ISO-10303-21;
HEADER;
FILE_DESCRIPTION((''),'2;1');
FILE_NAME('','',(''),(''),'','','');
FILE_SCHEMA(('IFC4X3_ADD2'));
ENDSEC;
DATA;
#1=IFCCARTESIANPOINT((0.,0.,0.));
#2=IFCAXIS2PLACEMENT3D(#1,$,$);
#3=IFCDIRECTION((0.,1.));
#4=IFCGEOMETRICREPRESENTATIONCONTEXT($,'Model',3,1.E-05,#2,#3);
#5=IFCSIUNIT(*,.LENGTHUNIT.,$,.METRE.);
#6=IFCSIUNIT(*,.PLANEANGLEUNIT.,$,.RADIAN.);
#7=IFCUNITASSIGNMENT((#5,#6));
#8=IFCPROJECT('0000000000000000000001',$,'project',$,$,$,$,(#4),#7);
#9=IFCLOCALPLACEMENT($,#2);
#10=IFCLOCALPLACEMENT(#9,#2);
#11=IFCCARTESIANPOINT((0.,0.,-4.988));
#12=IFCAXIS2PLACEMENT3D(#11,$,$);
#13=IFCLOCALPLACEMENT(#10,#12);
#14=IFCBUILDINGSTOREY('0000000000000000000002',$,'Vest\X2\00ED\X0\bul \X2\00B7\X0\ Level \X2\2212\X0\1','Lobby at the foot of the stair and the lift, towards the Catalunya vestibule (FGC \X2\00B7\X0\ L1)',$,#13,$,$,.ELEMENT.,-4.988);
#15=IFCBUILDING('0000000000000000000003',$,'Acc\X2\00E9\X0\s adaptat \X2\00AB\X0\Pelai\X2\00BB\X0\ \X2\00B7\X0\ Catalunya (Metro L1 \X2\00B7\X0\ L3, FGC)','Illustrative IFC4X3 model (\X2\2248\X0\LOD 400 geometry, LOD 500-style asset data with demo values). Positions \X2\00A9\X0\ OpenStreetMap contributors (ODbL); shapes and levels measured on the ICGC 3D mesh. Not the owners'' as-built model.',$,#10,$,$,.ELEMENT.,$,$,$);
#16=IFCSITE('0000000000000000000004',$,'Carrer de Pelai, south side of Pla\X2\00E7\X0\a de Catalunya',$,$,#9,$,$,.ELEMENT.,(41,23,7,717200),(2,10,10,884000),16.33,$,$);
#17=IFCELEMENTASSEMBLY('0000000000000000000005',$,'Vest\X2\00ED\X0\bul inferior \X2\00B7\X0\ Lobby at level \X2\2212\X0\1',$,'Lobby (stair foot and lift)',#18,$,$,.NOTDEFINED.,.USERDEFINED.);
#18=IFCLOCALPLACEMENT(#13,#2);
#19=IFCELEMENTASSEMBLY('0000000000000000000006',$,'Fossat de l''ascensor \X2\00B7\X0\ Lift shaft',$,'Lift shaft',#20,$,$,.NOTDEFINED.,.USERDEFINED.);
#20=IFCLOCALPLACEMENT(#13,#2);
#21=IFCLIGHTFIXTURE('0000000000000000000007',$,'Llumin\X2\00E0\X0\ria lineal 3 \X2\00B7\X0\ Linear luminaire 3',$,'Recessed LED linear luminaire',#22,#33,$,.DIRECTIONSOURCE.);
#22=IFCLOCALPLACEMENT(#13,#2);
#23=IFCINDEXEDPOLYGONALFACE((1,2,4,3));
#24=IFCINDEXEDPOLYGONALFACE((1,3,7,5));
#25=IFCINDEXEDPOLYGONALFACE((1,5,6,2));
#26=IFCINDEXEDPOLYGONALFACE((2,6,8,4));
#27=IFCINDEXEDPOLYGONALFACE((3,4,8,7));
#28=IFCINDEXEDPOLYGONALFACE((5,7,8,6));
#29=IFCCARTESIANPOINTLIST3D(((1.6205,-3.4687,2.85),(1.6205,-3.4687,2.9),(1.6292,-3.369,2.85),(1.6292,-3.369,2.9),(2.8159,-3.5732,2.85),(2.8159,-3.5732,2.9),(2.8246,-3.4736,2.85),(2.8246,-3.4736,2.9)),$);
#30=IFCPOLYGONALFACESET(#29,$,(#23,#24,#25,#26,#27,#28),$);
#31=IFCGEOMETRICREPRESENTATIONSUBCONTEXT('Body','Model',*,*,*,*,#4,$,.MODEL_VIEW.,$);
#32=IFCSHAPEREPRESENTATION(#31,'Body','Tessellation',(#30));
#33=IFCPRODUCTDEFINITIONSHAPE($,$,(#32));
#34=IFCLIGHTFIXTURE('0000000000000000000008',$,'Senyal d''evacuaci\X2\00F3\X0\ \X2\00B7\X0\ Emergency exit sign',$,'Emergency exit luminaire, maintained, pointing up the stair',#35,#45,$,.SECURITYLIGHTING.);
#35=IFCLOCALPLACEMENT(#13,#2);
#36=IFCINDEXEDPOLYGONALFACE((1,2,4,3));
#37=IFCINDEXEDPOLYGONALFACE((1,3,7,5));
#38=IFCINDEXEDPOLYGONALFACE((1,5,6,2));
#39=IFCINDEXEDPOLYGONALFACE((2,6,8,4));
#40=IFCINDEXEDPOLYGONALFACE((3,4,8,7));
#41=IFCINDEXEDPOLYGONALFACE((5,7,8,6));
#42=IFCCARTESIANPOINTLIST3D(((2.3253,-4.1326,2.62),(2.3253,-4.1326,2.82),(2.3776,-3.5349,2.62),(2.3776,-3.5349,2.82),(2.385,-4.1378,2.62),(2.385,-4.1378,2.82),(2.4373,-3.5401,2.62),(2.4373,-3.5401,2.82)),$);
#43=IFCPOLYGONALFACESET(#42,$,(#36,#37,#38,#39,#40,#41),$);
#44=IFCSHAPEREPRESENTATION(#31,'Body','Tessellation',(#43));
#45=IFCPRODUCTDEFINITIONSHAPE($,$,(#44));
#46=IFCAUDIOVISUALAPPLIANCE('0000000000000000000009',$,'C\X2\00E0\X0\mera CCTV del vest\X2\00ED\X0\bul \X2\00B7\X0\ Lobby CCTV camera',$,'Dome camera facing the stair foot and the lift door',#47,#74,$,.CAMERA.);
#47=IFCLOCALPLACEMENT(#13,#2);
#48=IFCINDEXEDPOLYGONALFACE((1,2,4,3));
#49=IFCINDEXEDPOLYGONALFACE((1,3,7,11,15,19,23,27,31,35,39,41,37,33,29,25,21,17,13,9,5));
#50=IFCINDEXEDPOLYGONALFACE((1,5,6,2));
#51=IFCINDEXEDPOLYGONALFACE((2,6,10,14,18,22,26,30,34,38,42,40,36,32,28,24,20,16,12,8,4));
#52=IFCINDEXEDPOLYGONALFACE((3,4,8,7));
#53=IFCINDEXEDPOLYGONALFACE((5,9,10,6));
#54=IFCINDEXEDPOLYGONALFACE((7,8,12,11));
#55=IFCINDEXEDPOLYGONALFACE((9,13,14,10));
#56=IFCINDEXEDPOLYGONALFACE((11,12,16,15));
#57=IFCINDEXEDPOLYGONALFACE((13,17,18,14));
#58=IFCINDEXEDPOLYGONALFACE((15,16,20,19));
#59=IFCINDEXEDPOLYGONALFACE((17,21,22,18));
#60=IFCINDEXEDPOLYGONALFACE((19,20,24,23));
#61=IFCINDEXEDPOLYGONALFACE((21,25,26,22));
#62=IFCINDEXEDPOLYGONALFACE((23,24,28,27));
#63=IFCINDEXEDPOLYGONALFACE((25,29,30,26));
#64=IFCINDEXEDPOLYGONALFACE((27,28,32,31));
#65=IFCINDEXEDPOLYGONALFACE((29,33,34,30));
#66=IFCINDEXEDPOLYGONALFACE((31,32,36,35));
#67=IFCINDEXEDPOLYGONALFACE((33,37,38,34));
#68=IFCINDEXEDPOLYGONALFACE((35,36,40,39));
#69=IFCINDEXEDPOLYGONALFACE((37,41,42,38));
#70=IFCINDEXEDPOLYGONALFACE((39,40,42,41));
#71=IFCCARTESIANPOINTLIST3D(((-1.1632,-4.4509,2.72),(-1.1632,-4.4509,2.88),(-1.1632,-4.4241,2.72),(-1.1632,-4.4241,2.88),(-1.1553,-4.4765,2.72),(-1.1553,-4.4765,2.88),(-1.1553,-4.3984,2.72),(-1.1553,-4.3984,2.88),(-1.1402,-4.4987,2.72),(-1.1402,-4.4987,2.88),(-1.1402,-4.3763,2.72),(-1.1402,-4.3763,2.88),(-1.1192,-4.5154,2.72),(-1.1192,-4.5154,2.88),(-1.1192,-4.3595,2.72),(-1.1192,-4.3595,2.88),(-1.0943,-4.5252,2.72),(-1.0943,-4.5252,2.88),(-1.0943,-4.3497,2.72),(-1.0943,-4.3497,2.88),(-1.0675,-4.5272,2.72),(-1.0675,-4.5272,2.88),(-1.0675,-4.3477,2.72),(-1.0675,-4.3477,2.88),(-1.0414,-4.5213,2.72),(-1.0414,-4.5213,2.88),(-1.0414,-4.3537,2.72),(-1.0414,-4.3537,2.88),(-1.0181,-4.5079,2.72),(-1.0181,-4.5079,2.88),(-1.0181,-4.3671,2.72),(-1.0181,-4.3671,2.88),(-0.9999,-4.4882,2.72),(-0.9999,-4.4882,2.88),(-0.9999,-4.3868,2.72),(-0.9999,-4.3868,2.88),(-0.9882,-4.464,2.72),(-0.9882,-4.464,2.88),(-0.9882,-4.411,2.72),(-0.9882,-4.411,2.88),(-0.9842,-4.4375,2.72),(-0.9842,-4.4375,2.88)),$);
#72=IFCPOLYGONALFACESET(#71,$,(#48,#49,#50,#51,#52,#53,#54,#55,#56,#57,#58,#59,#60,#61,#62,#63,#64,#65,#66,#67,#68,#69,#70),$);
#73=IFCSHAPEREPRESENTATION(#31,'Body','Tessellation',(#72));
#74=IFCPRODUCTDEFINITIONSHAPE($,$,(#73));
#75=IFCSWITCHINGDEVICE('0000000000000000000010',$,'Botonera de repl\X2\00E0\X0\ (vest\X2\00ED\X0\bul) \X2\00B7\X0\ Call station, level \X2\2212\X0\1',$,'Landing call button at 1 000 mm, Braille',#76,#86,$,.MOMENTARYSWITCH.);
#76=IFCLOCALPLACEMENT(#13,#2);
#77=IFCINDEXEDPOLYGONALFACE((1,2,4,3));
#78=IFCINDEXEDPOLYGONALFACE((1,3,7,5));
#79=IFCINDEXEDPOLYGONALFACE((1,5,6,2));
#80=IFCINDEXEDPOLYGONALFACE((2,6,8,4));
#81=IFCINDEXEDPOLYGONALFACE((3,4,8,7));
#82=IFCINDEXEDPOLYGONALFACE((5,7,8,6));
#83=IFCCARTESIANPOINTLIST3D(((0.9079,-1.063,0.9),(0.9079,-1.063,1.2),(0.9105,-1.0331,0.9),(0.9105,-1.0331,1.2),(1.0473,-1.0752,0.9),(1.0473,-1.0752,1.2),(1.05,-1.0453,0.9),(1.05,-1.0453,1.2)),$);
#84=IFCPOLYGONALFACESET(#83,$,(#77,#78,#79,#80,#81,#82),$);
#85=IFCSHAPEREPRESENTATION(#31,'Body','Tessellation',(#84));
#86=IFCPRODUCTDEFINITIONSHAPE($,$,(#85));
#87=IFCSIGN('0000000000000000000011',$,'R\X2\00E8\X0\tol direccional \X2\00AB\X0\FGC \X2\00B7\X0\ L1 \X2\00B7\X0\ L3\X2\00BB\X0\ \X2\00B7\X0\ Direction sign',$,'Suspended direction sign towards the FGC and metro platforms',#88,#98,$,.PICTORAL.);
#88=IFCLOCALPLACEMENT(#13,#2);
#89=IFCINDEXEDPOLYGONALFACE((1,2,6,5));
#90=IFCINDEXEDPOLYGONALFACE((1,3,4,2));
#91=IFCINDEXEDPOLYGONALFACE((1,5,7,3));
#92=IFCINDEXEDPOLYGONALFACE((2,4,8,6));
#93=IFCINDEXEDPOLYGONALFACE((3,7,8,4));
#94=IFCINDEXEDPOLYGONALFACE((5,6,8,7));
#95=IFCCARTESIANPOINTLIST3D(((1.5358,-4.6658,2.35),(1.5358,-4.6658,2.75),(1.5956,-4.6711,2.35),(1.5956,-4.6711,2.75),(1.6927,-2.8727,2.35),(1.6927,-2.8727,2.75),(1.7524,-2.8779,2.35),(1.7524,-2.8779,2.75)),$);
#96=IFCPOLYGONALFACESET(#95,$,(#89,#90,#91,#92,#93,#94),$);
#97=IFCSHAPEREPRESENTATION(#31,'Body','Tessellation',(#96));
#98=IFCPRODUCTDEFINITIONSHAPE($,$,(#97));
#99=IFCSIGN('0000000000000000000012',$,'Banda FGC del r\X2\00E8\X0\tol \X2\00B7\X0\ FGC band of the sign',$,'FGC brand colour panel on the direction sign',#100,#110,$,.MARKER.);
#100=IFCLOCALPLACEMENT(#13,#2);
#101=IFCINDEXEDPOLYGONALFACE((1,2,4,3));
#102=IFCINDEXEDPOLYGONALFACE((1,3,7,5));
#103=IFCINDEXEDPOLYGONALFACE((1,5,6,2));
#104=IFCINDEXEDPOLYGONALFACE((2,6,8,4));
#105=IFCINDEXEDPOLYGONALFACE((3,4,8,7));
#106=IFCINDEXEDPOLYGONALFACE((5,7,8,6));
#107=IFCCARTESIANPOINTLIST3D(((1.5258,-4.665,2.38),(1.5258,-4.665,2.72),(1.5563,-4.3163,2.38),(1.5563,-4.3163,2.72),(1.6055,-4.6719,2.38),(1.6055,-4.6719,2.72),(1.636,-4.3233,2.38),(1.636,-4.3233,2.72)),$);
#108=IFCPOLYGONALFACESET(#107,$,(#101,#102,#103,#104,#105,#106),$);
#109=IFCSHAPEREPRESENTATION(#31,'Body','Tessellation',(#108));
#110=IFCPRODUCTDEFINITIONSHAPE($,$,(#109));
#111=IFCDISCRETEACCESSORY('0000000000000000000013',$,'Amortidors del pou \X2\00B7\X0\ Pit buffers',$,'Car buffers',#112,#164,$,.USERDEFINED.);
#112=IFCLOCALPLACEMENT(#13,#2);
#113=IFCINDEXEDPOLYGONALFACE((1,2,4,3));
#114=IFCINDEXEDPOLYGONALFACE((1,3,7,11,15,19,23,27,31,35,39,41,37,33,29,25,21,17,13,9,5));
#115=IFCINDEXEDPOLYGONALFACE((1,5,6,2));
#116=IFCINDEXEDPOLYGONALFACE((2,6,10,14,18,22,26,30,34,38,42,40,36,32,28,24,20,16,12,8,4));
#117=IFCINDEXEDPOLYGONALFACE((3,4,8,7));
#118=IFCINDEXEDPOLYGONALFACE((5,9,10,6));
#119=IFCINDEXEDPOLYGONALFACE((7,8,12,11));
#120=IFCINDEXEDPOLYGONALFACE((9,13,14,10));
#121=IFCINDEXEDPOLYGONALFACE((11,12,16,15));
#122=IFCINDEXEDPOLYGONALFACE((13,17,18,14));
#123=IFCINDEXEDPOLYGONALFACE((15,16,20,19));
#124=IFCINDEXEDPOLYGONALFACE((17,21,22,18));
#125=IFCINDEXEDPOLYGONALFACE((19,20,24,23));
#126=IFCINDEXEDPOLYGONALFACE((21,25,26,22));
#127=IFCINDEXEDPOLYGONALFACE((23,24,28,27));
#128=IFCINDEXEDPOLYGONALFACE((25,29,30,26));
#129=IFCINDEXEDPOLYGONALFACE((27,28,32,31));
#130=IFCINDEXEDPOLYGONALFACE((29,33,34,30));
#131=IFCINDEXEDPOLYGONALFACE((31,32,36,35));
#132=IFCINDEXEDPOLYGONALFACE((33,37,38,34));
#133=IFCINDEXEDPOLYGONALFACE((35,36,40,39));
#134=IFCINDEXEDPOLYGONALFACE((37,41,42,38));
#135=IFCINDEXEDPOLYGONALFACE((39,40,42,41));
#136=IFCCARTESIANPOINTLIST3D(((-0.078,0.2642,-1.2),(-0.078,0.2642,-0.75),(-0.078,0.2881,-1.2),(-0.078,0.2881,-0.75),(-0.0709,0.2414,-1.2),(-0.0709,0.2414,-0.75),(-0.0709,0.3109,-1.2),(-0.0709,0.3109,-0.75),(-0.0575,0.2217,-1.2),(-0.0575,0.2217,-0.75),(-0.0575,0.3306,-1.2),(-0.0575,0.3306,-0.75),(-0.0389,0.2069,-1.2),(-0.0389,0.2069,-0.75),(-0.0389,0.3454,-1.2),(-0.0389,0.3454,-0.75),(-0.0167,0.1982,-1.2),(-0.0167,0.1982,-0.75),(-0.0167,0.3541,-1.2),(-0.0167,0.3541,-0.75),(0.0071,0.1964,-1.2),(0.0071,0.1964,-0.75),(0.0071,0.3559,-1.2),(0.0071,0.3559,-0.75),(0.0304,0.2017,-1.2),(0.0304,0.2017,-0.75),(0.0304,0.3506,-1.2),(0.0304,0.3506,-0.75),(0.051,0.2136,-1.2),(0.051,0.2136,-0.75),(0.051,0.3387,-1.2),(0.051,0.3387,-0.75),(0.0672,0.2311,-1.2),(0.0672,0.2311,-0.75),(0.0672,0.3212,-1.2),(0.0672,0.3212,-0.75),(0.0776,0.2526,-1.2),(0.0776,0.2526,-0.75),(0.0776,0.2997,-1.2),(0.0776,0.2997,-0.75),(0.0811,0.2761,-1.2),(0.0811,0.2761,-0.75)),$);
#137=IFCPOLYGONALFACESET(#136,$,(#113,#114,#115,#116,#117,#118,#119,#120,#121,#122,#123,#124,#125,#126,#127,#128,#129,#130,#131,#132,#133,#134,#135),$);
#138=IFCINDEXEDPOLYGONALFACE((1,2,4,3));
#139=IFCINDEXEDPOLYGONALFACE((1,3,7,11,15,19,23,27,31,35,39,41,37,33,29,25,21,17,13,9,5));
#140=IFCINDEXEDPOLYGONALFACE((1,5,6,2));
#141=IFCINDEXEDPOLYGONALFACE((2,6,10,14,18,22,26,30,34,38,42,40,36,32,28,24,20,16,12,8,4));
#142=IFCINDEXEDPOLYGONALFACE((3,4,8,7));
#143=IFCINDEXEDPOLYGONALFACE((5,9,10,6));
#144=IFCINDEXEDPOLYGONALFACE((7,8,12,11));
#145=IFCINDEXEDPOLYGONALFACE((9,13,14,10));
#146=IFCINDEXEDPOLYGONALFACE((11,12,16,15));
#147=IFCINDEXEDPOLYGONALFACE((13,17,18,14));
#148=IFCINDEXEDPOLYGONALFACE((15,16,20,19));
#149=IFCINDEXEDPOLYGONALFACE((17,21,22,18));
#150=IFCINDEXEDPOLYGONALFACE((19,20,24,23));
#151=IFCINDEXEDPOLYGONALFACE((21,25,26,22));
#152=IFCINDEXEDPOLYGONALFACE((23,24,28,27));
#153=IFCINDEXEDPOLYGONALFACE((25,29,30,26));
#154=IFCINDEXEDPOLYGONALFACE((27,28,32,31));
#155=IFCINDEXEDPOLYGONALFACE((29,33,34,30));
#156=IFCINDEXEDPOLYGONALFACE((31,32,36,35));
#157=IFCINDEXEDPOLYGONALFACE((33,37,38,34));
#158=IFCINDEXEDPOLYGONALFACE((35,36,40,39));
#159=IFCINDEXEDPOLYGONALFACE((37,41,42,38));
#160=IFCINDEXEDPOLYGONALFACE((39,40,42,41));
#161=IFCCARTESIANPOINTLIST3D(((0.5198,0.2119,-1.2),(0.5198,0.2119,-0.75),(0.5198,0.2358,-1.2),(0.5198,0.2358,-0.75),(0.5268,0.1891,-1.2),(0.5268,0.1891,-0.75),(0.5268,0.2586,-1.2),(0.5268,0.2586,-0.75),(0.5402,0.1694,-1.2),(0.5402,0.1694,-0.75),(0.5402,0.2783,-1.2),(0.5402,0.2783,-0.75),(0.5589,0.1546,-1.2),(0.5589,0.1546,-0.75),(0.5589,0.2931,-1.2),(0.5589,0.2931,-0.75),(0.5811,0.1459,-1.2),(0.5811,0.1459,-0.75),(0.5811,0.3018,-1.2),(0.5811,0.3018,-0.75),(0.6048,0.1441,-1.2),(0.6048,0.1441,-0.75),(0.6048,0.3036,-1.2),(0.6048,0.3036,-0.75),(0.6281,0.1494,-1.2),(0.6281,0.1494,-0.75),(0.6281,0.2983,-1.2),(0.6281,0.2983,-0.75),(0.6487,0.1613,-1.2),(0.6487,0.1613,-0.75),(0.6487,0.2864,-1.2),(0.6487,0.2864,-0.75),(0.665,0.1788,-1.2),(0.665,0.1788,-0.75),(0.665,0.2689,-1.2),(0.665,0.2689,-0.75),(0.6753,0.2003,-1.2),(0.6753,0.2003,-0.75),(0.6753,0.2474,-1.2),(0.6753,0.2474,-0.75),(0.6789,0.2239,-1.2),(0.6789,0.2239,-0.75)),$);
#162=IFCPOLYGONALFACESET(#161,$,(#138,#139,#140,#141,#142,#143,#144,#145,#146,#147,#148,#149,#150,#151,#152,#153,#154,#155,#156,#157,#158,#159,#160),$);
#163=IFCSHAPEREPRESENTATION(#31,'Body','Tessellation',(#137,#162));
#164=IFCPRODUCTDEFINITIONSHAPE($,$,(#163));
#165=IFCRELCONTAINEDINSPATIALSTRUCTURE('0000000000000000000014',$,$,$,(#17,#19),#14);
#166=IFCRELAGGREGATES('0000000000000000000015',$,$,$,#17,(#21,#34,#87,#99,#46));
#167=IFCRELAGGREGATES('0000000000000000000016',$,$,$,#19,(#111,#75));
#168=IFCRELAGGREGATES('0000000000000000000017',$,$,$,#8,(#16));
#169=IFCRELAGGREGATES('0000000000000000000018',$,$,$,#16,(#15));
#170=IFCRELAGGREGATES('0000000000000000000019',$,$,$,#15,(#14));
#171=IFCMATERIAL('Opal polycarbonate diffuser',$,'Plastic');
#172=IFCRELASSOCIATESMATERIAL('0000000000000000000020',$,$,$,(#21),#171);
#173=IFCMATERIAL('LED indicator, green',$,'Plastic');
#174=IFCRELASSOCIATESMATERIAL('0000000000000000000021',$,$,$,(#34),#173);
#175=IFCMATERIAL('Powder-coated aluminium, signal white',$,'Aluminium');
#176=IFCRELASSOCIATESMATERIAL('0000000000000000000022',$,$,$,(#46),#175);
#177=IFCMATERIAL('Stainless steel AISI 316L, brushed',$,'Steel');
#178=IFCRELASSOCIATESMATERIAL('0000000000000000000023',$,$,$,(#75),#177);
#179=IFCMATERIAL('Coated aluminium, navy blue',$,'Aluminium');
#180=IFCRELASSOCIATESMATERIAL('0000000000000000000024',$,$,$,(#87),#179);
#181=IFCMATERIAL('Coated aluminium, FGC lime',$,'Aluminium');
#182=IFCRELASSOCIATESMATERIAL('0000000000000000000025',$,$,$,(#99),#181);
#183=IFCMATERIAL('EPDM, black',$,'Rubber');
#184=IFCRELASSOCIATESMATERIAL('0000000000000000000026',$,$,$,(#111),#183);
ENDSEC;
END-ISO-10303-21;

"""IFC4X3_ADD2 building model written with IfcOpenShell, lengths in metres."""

from ifc_helpers import new_model, si_unit, direction, frame, frame_2d, origin, origin_2d_with_axis, place, context, subcontext, project, spatial, rectangle, circle, extrude, material, element, aggregate, save


model = new_model("IFC4X3_ADD2")

# Units and contexts
model_context = context("Model", 3, precision=1e-05, world=origin(), true_north=direction((0.0, 1.0)))
body_context = subcontext(model_context, "Body", "Model", "MODEL_VIEW")
ifc_project = project(units=[si_unit("LENGTHUNIT", "METRE"), si_unit("PLANEANGLEUNIT", "RADIAN")], contexts=[model_context])

# Site, building, storey
site_placement = place(None, origin())
site = spatial("IfcSite", under=ifc_project, at=site_placement, Name="Carrer de Pelai, south side of Plaça de Catalunya", CompositionType="ELEMENT", RefLatitude=(41, 23, 7, 717200), RefLongitude=(2, 10, 10, 884000), RefElevation=16.33)
building_placement = place(site_placement, origin())
building = spatial("IfcBuilding", under=site, at=building_placement, Name="Accés adaptat «Pelai» · Catalunya (Metro L1 · L3, FGC)", Description="Illustrative IFC4X3 model (≈LOD 400 geometry, LOD 500-style asset data with demo values). Positions © OpenStreetMap contributors (ODbL); shapes and levels measured on the ICGC 3D mesh. Not the owners' as-built model.", CompositionType="ELEMENT")
storey_placement = place(building_placement, frame((0.0, 0.0, -4.988)))
storey = spatial("IfcBuildingStorey", under=building, at=storey_placement, Name="Vestíbul · Level −1", Description="Lobby at the foot of the stair and the lift, towards the Catalunya vestibule (FGC · L1)", CompositionType="ELEMENT", Elevation=-4.988)

# Element assembly
assembly_1_placement = place(building_placement, origin())
assembly_1 = element("IfcElementAssembly", 1, at=assembly_1_placement, inside=storey, Name="Vestíbul inferior · Lobby at level −1", ObjectType="Lobby (stair foot and lift)", AssemblyPlace="NOTDEFINED", PredefinedType="USERDEFINED")

# Element assembly
assembly_2_placement = place(building_placement, origin())
assembly_2 = element("IfcElementAssembly", 2, at=assembly_2_placement, inside=storey, Name="Fossat de l'ascensor · Lift shaft", ObjectType="Lift shaft", AssemblyPlace="NOTDEFINED", PredefinedType="USERDEFINED")

# Shared definitions
ifc_material_1 = material(Name="Stainless steel AISI 316L, brushed", Category="Steel")

# Light fixtures
ifc_material_2 = material(Name="Opal polycarbonate diffuser", Category="Plastic")
light_fixture_1_placement = place(building_placement, origin())
light_fixture_1 = element("IfcLightFixture", 3, at=light_fixture_1_placement, material=ifc_material_2, Name="Lluminària lineal 3 · Linear luminaire 3", ObjectType="Recessed LED linear luminaire", PredefinedType="DIRECTIONSOURCE", context=body_context, shape_type="SweptSolid", body=[
    extrude(rectangle(XDim=1.2, YDim=0.1, at=frame_2d((0.0, 0.0), x_axis=(0.996195, -0.087156))), frame((2.2225, -3.4711, -2.138)), (0.0, 0.0, 1.0), 0.05),
])
ifc_material_3 = material(Name="LED indicator, green", Category="Plastic")
light_fixture_2_placement = place(building_placement, origin())
light_fixture_2 = element("IfcLightFixture", 4, at=light_fixture_2_placement, material=ifc_material_3, Name="Senyal d'evacuació · Emergency exit sign", ObjectType="Emergency exit luminaire, maintained, pointing up the stair", PredefinedType="SECURITYLIGHTING", context=body_context, shape_type="SweptSolid", body=[
    extrude(rectangle(XDim=0.06, YDim=0.6, at=frame_2d((0.0, 0.0), x_axis=(0.996195, -0.087156))), frame((2.3813, -3.8364, -2.368)), (0.0, 0.0, 1.0), 0.2),
])

# Audio visual appliance
ifc_material_4 = material(Name="Powder-coated aluminium, signal white", Category="Aluminium")
audio_visual_appliance_placement = place(building_placement, origin())
audio_visual_appliance = element("IfcAudioVisualAppliance", 5, at=audio_visual_appliance_placement, material=ifc_material_4, Name="Càmera CCTV del vestíbul · Lobby CCTV camera", ObjectType="Dome camera facing the stair foot and the lift door", PredefinedType="CAMERA", context=body_context, shape_type="SweptSolid", body=[
    extrude(circle(Radius=0.09, at=origin_2d_with_axis()), frame((-1.0742, -4.4375, -2.268)), (0.0, 0.0, 1.0), 0.16),
])

# Switching device
switching_device_placement = place(building_placement, origin())
switching_device = element("IfcSwitchingDevice", 6, at=switching_device_placement, material=ifc_material_1, Name="Botonera de replà (vestíbul) · Call station, level −1", ObjectType="Landing call button at 1 000 mm, Braille", PredefinedType="MOMENTARYSWITCH", context=body_context, shape_type="SweptSolid", body=[
    extrude(rectangle(XDim=0.14, YDim=0.03, at=frame_2d((0.0, 0.0), x_axis=(0.996195, -0.087156))), frame((0.9789, -1.0541, -4.088)), (0.0, 0.0, 1.0), 0.3),
])

# Signs
ifc_material_5 = material(Name="Coated aluminium, navy blue", Category="Aluminium")
sign_1_placement = place(building_placement, origin())
sign_1 = element("IfcSign", 7, at=sign_1_placement, material=ifc_material_5, Name="Rètol direccional «FGC · L1 · L3» · Direction sign", ObjectType="Suspended direction sign towards the FGC and metro platforms", PredefinedType="PICTORAL", context=body_context, shape_type="SweptSolid", body=[
    extrude(rectangle(XDim=0.06, YDim=1.8, at=frame_2d((0.0, 0.0), x_axis=(0.996195, -0.087156))), frame((1.6441, -3.7719, -2.638)), (0.0, 0.0, 1.0), 0.4),
])
ifc_material_6 = material(Name="Coated aluminium, FGC lime", Category="Aluminium")
sign_2_placement = place(building_placement, origin())
sign_2 = element("IfcSign", 8, at=sign_2_placement, material=ifc_material_6, Name="Banda FGC del rètol · FGC band of the sign", ObjectType="FGC brand colour panel on the direction sign", PredefinedType="MARKER", context=body_context, shape_type="SweptSolid", body=[
    extrude(rectangle(XDim=0.08, YDim=0.35, at=frame_2d((0.0, 0.0), x_axis=(0.996195, -0.087156))), frame((1.5809, -4.4941, -2.608)), (0.0, 0.0, 1.0), 0.34),
])
aggregate(assembly_1, [light_fixture_1, light_fixture_2, sign_1, sign_2, audio_visual_appliance])

# Discrete accessory
ifc_material_7 = material(Name="EPDM, black", Category="Rubber")
discrete_accessory_placement = place(building_placement, origin())
discrete_accessory = element("IfcDiscreteAccessory", 9, at=discrete_accessory_placement, material=ifc_material_7, Name="Amortidors del pou · Pit buffers", ObjectType="Car buffers", PredefinedType="USERDEFINED", context=body_context, shape_type="SweptSolid", body=[
    extrude(circle(Radius=0.08, at=origin_2d_with_axis()), frame((0.0011, 0.2761, -6.188)), (0.0, 0.0, 1.0), 0.45),
    extrude(circle(Radius=0.08, at=origin_2d_with_axis()), frame((0.5989, 0.2239, -6.188)), (0.0, 0.0, 1.0), 0.45),
])
aggregate(assembly_2, [discrete_accessory, switching_device])

save(model, "model.ifc")
